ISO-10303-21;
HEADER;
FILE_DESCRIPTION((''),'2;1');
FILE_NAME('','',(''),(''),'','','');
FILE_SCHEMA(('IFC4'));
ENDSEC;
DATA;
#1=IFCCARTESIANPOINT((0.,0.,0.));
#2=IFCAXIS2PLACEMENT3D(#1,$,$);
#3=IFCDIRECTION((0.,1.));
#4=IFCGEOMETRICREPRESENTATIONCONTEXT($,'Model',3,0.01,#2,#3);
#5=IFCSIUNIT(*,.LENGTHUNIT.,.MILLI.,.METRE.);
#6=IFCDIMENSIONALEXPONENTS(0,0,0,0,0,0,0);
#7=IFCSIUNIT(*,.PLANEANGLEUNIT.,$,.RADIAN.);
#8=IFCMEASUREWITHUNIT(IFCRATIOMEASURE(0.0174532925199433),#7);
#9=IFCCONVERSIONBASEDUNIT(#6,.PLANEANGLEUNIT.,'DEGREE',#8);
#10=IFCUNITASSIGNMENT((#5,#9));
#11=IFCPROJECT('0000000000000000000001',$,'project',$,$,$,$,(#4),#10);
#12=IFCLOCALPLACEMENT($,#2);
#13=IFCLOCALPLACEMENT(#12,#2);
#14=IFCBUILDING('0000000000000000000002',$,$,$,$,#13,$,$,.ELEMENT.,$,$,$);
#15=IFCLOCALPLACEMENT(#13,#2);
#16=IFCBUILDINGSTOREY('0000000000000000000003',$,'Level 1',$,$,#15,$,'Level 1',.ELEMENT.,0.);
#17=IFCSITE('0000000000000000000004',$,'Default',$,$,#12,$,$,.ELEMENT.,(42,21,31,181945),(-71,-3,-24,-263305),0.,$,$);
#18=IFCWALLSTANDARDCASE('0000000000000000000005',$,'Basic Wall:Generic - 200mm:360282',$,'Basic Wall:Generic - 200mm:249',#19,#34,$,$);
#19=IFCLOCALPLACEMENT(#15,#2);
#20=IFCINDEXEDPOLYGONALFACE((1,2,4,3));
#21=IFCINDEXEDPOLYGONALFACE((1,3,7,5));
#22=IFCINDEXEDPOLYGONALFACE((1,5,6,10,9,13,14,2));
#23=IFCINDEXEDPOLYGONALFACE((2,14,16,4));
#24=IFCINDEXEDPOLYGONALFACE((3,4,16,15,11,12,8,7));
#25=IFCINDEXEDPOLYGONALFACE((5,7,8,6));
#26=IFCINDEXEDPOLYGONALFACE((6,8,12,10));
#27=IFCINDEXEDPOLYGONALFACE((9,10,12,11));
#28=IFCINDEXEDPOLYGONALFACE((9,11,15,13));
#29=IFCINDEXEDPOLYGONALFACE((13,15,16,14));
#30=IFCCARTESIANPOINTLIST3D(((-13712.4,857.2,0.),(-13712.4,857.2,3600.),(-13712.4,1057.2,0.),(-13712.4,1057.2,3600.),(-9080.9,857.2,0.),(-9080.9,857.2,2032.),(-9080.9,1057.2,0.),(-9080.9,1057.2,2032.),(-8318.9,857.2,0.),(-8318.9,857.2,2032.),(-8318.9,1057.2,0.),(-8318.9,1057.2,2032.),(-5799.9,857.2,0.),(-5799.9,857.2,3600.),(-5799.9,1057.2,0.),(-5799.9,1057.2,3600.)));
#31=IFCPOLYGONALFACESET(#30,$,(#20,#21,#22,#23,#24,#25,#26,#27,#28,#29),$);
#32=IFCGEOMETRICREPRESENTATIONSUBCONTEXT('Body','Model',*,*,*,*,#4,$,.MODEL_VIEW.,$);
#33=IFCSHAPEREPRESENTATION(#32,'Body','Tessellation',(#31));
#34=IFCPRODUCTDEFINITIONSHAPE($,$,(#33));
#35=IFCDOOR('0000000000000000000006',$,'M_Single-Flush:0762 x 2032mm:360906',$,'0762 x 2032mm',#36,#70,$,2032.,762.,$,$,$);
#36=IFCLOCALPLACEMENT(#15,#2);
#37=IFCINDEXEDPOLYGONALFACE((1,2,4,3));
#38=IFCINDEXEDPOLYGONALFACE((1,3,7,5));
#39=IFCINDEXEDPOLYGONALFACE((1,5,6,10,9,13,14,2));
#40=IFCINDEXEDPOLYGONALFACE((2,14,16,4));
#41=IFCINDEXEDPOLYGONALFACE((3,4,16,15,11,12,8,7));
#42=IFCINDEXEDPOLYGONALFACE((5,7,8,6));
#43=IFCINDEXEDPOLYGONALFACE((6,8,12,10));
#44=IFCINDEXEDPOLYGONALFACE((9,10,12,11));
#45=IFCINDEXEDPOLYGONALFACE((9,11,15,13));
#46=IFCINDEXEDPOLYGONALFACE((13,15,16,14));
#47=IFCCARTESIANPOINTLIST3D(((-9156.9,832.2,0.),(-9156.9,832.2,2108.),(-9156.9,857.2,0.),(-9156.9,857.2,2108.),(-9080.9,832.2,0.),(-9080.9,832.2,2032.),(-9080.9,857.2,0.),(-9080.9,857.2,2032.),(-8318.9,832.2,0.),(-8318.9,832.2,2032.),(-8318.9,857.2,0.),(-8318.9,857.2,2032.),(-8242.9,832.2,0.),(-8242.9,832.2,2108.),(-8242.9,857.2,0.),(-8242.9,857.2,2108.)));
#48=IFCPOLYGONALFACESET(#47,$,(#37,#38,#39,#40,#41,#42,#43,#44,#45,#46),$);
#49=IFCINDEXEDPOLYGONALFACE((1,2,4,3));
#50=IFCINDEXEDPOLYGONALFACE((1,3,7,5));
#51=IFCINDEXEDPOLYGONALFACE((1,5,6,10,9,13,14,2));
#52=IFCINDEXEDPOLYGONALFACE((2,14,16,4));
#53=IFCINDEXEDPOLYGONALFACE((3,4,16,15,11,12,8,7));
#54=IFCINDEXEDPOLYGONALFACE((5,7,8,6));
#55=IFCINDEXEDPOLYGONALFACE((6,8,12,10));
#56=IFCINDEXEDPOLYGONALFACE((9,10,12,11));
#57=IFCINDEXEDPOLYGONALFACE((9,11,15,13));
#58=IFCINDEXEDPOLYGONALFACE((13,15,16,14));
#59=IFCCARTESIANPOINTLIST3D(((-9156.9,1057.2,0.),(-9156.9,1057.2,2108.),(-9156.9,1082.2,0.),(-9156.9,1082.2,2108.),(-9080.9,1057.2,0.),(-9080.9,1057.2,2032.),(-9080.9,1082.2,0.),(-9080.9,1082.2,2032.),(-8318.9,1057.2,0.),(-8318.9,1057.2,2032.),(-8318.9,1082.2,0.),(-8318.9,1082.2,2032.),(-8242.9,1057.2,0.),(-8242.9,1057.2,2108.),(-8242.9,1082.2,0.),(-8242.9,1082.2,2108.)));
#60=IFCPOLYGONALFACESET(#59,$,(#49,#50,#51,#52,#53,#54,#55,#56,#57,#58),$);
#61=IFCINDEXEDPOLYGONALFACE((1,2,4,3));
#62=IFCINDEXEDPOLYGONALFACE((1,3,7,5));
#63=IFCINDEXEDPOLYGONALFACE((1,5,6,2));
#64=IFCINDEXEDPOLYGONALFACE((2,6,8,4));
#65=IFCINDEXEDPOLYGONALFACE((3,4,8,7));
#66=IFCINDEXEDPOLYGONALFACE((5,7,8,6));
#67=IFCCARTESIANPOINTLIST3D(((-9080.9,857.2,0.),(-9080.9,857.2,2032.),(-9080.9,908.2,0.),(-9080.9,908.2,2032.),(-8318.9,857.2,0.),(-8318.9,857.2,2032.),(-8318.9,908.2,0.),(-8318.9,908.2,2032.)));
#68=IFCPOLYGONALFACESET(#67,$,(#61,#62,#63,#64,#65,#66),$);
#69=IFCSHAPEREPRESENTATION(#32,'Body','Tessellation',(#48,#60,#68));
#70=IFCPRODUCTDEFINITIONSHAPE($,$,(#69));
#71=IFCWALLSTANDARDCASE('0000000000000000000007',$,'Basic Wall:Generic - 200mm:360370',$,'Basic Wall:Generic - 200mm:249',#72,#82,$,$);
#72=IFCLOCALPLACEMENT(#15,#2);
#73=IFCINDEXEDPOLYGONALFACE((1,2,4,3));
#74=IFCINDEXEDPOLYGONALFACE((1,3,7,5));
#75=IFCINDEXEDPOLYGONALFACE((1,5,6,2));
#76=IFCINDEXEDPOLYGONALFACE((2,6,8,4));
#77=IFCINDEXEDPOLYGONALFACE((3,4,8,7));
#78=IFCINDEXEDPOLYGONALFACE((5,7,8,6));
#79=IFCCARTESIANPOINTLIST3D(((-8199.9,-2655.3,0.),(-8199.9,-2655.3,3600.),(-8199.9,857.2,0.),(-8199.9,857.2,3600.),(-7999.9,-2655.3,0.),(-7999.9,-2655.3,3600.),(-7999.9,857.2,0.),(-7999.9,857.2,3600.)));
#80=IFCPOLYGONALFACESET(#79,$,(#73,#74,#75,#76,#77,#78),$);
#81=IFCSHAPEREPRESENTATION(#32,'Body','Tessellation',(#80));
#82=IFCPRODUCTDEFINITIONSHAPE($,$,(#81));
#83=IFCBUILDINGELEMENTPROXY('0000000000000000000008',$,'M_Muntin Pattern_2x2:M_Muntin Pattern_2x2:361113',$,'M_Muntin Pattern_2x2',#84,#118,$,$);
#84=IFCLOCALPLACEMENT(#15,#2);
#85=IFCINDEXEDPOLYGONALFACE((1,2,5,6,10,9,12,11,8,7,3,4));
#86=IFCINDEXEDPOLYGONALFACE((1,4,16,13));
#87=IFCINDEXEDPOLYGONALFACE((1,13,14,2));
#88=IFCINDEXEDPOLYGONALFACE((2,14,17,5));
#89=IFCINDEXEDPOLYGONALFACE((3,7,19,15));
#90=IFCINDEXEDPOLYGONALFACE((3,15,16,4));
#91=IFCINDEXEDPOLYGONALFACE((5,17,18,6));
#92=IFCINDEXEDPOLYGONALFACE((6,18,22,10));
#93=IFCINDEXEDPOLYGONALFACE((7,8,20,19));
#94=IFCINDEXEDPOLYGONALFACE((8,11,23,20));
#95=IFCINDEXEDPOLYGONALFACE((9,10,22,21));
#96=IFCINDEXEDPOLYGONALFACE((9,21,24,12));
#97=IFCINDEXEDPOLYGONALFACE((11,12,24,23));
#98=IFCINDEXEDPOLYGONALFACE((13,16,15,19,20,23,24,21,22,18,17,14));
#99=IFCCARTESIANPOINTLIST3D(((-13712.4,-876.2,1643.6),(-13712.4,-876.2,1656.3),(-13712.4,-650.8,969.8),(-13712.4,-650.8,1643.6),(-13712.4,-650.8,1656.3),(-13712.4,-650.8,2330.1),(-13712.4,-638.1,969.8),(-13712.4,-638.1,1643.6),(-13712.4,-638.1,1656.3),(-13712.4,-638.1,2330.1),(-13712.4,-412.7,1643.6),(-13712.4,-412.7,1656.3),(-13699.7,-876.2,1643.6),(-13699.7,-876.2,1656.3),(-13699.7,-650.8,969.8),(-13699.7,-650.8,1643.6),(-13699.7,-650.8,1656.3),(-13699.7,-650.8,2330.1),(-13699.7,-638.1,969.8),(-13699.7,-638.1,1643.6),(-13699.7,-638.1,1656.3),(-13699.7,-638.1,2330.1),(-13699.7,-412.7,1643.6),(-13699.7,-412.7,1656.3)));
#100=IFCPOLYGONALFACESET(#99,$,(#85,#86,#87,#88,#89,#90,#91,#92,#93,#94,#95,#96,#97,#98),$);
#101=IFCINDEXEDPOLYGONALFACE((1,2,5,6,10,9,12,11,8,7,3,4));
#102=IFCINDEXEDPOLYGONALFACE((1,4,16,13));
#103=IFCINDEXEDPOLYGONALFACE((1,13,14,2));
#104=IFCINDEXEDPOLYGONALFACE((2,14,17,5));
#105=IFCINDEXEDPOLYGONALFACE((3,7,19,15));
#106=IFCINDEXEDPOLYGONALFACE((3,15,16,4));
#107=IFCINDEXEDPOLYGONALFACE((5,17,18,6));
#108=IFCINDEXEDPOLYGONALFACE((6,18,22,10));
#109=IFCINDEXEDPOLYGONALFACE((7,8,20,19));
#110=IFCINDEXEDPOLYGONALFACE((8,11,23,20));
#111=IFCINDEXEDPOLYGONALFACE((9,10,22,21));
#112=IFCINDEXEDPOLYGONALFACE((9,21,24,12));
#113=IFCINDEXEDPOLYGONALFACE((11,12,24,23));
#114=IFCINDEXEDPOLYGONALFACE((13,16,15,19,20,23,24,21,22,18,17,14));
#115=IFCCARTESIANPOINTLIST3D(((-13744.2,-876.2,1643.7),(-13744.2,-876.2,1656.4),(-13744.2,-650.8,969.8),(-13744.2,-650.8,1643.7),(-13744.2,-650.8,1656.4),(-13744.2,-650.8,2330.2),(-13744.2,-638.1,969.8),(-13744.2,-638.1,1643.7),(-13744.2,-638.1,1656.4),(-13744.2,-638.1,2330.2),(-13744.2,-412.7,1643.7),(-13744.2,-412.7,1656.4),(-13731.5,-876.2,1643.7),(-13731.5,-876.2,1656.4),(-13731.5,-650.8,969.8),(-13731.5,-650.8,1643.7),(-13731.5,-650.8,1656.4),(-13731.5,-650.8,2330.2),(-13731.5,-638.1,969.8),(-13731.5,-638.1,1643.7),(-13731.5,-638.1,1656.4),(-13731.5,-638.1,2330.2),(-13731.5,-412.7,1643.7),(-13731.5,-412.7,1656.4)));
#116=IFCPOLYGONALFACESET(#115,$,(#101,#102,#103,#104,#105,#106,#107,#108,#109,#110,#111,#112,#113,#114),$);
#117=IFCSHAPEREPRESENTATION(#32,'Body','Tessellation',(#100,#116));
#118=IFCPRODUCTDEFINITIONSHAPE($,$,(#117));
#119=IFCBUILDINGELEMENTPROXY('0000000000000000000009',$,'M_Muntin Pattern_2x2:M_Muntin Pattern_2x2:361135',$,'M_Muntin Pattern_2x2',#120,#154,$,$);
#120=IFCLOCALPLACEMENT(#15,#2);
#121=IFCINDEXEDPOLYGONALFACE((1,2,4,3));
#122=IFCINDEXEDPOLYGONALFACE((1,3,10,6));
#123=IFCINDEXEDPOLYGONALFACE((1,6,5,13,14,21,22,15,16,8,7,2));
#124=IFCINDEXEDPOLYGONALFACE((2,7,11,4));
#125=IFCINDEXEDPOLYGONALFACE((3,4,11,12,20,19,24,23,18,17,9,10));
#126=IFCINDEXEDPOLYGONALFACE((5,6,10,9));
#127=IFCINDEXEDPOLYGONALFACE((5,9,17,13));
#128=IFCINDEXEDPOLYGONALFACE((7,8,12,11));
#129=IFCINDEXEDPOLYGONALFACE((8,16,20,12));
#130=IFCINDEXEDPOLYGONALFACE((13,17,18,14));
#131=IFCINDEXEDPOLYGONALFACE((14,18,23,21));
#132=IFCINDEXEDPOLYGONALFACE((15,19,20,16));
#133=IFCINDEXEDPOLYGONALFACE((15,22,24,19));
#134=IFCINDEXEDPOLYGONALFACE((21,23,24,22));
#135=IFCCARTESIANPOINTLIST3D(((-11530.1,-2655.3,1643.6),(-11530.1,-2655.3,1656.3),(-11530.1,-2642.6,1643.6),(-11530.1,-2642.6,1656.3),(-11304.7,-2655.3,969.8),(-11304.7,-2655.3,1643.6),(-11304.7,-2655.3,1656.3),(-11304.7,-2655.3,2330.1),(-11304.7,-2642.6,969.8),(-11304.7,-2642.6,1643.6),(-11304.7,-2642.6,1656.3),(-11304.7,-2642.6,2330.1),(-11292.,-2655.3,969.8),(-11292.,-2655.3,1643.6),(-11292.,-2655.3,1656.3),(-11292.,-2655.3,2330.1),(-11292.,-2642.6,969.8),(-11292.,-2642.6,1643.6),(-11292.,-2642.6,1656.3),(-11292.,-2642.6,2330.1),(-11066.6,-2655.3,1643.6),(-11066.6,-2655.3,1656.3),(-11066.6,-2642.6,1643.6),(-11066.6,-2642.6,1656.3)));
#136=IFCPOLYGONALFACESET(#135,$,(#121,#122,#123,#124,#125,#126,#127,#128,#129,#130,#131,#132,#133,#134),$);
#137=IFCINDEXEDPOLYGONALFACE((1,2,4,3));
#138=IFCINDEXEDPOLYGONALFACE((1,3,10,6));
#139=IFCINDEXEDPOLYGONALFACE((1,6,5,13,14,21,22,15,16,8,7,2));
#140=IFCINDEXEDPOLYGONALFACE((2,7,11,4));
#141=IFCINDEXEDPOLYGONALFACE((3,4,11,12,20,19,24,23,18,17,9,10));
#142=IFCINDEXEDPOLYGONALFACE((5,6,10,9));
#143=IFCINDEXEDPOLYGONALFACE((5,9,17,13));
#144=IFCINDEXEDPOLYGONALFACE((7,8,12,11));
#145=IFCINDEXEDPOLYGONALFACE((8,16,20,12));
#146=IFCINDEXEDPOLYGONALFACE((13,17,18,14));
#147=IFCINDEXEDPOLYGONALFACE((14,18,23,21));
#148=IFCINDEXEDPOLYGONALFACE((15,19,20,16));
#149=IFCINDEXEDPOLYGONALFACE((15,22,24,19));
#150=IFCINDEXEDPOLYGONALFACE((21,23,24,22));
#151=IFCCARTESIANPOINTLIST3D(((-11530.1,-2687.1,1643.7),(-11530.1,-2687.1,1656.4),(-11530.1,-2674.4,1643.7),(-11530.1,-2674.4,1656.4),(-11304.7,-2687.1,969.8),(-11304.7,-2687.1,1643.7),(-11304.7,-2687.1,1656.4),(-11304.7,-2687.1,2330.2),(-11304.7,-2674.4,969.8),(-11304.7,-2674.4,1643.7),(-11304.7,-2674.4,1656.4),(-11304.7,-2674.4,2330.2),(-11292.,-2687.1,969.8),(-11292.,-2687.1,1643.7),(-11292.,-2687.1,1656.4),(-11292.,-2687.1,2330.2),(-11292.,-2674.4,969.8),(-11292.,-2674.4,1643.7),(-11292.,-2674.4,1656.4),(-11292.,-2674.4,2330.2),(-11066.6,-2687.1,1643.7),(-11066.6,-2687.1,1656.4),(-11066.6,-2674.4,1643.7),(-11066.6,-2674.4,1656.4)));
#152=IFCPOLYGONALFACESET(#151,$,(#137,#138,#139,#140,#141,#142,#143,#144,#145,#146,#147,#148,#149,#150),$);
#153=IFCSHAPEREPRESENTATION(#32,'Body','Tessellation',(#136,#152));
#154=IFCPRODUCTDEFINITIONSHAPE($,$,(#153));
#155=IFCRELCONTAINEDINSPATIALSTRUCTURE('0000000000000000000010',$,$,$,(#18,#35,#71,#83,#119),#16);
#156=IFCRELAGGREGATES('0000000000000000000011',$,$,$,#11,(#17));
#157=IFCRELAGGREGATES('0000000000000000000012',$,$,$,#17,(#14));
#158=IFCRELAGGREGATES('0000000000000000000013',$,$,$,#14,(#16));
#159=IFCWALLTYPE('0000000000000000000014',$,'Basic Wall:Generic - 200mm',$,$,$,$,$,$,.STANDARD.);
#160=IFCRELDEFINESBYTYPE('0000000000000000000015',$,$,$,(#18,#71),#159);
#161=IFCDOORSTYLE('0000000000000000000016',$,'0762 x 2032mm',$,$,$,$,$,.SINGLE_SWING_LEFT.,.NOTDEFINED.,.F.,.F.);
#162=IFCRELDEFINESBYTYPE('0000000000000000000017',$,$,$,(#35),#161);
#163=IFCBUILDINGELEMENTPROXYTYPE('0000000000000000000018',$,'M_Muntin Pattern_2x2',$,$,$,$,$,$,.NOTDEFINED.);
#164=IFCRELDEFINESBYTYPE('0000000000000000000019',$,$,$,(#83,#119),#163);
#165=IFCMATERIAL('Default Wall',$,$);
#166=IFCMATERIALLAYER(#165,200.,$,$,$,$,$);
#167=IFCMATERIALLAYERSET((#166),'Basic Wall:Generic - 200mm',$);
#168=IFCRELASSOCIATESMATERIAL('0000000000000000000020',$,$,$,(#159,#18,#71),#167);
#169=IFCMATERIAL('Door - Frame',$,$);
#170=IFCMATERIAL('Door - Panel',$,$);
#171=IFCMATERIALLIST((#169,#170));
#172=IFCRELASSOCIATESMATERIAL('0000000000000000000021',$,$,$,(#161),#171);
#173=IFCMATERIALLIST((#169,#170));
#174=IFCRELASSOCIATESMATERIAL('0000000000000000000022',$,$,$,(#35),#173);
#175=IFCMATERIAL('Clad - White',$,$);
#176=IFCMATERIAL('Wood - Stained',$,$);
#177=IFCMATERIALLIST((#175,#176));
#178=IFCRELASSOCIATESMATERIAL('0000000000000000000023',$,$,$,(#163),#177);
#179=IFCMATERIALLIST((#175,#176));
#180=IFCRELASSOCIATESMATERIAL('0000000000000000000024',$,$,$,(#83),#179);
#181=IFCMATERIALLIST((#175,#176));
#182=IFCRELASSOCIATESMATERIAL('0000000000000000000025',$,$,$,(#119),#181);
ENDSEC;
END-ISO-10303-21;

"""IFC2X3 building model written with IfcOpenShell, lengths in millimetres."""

from ifc_helpers import new_model, entity, si_unit, converted_unit, direction, frame, frame_2d, origin, place, context, subcontext, project, spatial, polyline, rectangle, outline, extrude, clip, bounded_halfspace, source, transform, mapped, material, material_list, layer, layer_set, layer_usage, type_object, type_shapes, element, fill, save


model = new_model("IFC2X3")

# Units and contexts
model_context = context("Model", 3, precision=0.01, world=origin(), true_north=direction((0.0, 1.0)))
body_context = subcontext(model_context, "Body", "Model", "MODEL_VIEW")
ifc_project = project(units=[si_unit("LENGTHUNIT", "METRE", prefix="MILLI"), converted_unit("PLANEANGLEUNIT", "DEGREE", entity("IfcRatioMeasure", 0.0174532925199433), si_unit("PLANEANGLEUNIT", "RADIAN"), dimensions=[0, 0, 0, 0, 0, 0, 0])], contexts=[model_context])

# Site, building, storey
site_placement = place(None, origin())
site = spatial("IfcSite", under=ifc_project, at=site_placement, Name="Default", CompositionType="ELEMENT", RefLatitude=(42, 21, 31, 181945), RefLongitude=(-71, -3, -24, -263305), RefElevation=0.0)
building_placement = place(site_placement, origin())
building = spatial("IfcBuilding", under=site, at=building_placement, CompositionType="ELEMENT")
storey_placement = place(building_placement, origin())
storey = spatial("IfcBuildingStorey", under=building, at=storey_placement, Name="Level 1", LongName="Level 1", CompositionType="ELEMENT", Elevation=0.0)

# Shared definitions
ifc_material_1 = material(Name="Default Wall")

# Wall, opening, door
ifc_material_2 = material(Name="Door - Frame")
ifc_material_3 = material(Name="Door - Panel")
ifc_layer_1 = layer(ifc_material_1, 200.0)
ifc_layer_set_1 = layer_set([ifc_layer_1], Name="Basic Wall:Generic - 200mm")
wall_type_1 = type_object("IfcWallType", Name="Basic Wall:Generic - 200mm", PredefinedType="STANDARD", material=ifc_layer_set_1)
ifc_material_list_1 = material_list([ifc_material_2, ifc_material_3])
door_style_1 = type_object("IfcDoorStyle", Name="0762 x 2032mm", ConstructionType="NOTDEFINED", OperationType="SINGLE_SWING_LEFT", ParameterTakesPrecedence=False, Sizeable=False, material=ifc_material_list_1)
shared_shape_1 = source(origin(), body_context, "Body", "SweptSolid", [
    extrude(outline(polyline([(-457.0, -1073.0), (457.0, -1073.0), (457.0, 1035.0), (381.0, 1035.0), (381.0, -997.0), (-381.0, -997.0), (-381.0, 1035.0), (-457.0, 1035.0), (-457.0, -1073.0)])), frame((381.0, 225.0, 1035.0), z_axis=(0.0, -1.0, 0.0), x_axis=(-1.0, 0.0, 0.0)), (0.0, 0.0, 1.0), 25.0),
    extrude(outline(polyline([(-1073.0, -457.0), (1035.0, -457.0), (1035.0, -381.0), (-997.0, -381.0), (-997.0, 381.0), (1035.0, 381.0), (1035.0, 457.0), (-1073.0, 457.0), (-1073.0, -457.0)])), frame((381.0, 0.0, 1035.0), z_axis=(0.0, -1.0, 0.0), x_axis=(0.0, 0.0, -1.0)), (0.0, 0.0, 1.0), 25.0),
    extrude(rectangle(XDim=762.0, YDim=51.0, at=frame_2d((0.0, 0.0), x_axis=(1.0, 0.0))), frame((381.0, 174.5, 0.0)), (0.0, 0.0, 1.0), 2032.0),
])
type_shapes(door_style_1, [shared_shape_1])
ifc_layer_usage_1 = layer_usage(ifc_layer_set_1, "AXIS2", "NEGATIVE", 100.0)
wall_1_placement = place(storey_placement, frame((-5799.9, 957.2, 0.0), z_axis=(0.0, 0.0, 1.0), x_axis=(-1.0, 0.0, 0.0)))
wall_1 = element("IfcWallStandardCase", 1, at=wall_1_placement, inside=storey, type_object=wall_type_1, material=ifc_layer_usage_1, Name="Basic Wall:Generic - 200mm:360282", ObjectType="Basic Wall:Generic - 200mm:249", context=body_context, shape_type="Clipping", body=[
    clip(extrude(rectangle(XDim=7912.5, YDim=200.0, at=frame_2d((3956.2, 0.0), x_axis=(-1.0, 0.0))), origin(), (0.0, 0.0, 1.0), 3600.0), bounded_halfspace(frame((0.0, -100.0, 3600.0), z_axis=(0.0, 0.0, -1.0), x_axis=(-1.0, 0.0, 0.0)), True, frame((0.0, -100.0, 3600.0)), polyline([(0.0, 0.0), (200.0, 0.0), (4500.0, 0.0), (4700.0, 0.0), (7912.5, 0.0), (7912.5, 200.0), (2400.0, 200.0), (2200.0, 200.0), (0.0, 200.0), (0.0, 0.0)]))),
])
opening_1_placement = place(wall_1_placement, frame((2519.0, -100.0, 0.0)))
opening_1 = element("IfcOpeningElement", 2, at=opening_1_placement, cuts=wall_1, ObjectType="Opening", context=body_context, shape_type="SweptSolid", body=[
    extrude(rectangle(XDim=762.0, YDim=2032.0, at=frame_2d((1016.0, 381.0), x_axis=(0.0, -1.0))), frame((0.0, 0.0, 0.0), z_axis=(0.0, 1.0, 0.0), x_axis=(0.0, 0.0, 1.0)), (0.0, 0.0, 1.0), 200.0),
])
ifc_material_list_2 = material_list([ifc_material_2, ifc_material_3])
door_1_placement = place(opening_1_placement, origin())
door_1 = element("IfcDoor", 3, at=door_1_placement, inside=storey, type_object=door_style_1, material=ifc_material_list_2, Name="M_Single-Flush:0762 x 2032mm:360906", ObjectType="0762 x 2032mm", OverallHeight=2032.0, OverallWidth=762.0, context=body_context, shape_type="MappedRepresentation", body=[
    mapped(shared_shape_1, transform((0.0, 0.0, 0.0), scale=1.0)),
])
fill(opening_1, door_1)

# Wall
ifc_layer_usage_2 = layer_usage(ifc_layer_set_1, "AXIS2", "NEGATIVE", 100.0)
wall_2_placement = place(storey_placement, frame((-8099.9, 857.2, 0.0), z_axis=(0.0, 0.0, 1.0), x_axis=(0.0, -1.0, 0.0)))
element("IfcWallStandardCase", 4, at=wall_2_placement, inside=storey, type_object=wall_type_1, material=ifc_layer_usage_2, Name="Basic Wall:Generic - 200mm:360370", ObjectType="Basic Wall:Generic - 200mm:249", context=body_context, shape_type="Clipping", body=[
    clip(extrude(rectangle(XDim=3512.5, YDim=200.0, at=frame_2d((1756.2, 0.0), x_axis=(-1.0, 0.0))), origin(), (0.0, 0.0, 1.0), 3600.0), bounded_halfspace(frame((0.0, -100.0, 3600.0), z_axis=(0.0, 0.0, -1.0), x_axis=(0.0, 1.0, 0.0)), True, frame((0.0, -100.0, 3600.0)), polyline([(0.0, 0.0), (3512.5, 0.0), (3512.5, 200.0), (0.0, 200.0), (0.0, 0.0)]))),
])

# Building element proxies
ifc_material_4 = material(Name="Clad - White")
ifc_material_5 = material(Name="Wood - Stained")
ifc_material_list_3 = material_list([ifc_material_4, ifc_material_5])
ifc_material_list_4 = material_list([ifc_material_4, ifc_material_5])
building_element_proxy_type_1 = type_object("IfcBuildingElementProxyType", Name="M_Muntin Pattern_2x2", PredefinedType="NOTDEFINED", material=ifc_material_list_4)
shared_shape_2 = source(origin(), body_context, "Body", "SweptSolid", [
    extrude(outline(polyline([(6.4, -6.4), (680.1, -6.4), (680.1, 6.3), (6.4, 6.3), (6.4, 231.7), (-6.3, 231.7), (-6.3, 6.3), (-680.2, 6.3), (-680.2, -6.4), (-6.3, -6.4), (-6.3, -231.7), (6.4, -231.7), (6.4, -6.4)])), frame((0.0, 9.5, 680.1), z_axis=(0.0, 1.0, 0.0), x_axis=(0.0, 0.0, 1.0)), (0.0, 0.0, 1.0), 12.7),
    extrude(outline(polyline([(6.4, -6.4), (680.2, -6.4), (680.2, 6.3), (6.4, 6.3), (6.4, 231.7), (-6.3, 231.7), (-6.3, 6.3), (-680.2, 6.3), (-680.2, -6.4), (-6.3, -6.4), (-6.3, -231.7), (6.4, -231.7), (6.4, -6.4)])), frame((0.0, -22.2, 680.2), z_axis=(0.0, 1.0, 0.0), x_axis=(0.0, 0.0, 1.0)), (0.0, 0.0, 1.0), 12.7),
])
type_shapes(building_element_proxy_type_1, [shared_shape_2])
proxy_1_placement = place(storey_placement, frame((-13722.0, -644.4, 969.8), z_axis=(0.0, 0.0, 1.0), x_axis=(0.0, -1.0, 0.0)))
element("IfcBuildingElementProxy", 5, at=proxy_1_placement, inside=storey, type_object=building_element_proxy_type_1, material=ifc_material_list_3, Name="M_Muntin Pattern_2x2:M_Muntin Pattern_2x2:361113", ObjectType="M_Muntin Pattern_2x2", context=body_context, shape_type="MappedRepresentation", body=[
    mapped(shared_shape_2, transform((0.0, 0.0, 0.0), scale=1.0)),
])
ifc_material_list_5 = material_list([ifc_material_4, ifc_material_5])
proxy_2_placement = place(storey_placement, frame((-11298.4, -2664.9, 969.8)))
element("IfcBuildingElementProxy", 6, at=proxy_2_placement, inside=storey, type_object=building_element_proxy_type_1, material=ifc_material_list_5, Name="M_Muntin Pattern_2x2:M_Muntin Pattern_2x2:361135", ObjectType="M_Muntin Pattern_2x2", context=body_context, shape_type="MappedRepresentation", body=[
    mapped(shared_shape_2, transform((0.0, 0.0, 0.0), scale=1.0)),
])

save(model, "model.ifc")
